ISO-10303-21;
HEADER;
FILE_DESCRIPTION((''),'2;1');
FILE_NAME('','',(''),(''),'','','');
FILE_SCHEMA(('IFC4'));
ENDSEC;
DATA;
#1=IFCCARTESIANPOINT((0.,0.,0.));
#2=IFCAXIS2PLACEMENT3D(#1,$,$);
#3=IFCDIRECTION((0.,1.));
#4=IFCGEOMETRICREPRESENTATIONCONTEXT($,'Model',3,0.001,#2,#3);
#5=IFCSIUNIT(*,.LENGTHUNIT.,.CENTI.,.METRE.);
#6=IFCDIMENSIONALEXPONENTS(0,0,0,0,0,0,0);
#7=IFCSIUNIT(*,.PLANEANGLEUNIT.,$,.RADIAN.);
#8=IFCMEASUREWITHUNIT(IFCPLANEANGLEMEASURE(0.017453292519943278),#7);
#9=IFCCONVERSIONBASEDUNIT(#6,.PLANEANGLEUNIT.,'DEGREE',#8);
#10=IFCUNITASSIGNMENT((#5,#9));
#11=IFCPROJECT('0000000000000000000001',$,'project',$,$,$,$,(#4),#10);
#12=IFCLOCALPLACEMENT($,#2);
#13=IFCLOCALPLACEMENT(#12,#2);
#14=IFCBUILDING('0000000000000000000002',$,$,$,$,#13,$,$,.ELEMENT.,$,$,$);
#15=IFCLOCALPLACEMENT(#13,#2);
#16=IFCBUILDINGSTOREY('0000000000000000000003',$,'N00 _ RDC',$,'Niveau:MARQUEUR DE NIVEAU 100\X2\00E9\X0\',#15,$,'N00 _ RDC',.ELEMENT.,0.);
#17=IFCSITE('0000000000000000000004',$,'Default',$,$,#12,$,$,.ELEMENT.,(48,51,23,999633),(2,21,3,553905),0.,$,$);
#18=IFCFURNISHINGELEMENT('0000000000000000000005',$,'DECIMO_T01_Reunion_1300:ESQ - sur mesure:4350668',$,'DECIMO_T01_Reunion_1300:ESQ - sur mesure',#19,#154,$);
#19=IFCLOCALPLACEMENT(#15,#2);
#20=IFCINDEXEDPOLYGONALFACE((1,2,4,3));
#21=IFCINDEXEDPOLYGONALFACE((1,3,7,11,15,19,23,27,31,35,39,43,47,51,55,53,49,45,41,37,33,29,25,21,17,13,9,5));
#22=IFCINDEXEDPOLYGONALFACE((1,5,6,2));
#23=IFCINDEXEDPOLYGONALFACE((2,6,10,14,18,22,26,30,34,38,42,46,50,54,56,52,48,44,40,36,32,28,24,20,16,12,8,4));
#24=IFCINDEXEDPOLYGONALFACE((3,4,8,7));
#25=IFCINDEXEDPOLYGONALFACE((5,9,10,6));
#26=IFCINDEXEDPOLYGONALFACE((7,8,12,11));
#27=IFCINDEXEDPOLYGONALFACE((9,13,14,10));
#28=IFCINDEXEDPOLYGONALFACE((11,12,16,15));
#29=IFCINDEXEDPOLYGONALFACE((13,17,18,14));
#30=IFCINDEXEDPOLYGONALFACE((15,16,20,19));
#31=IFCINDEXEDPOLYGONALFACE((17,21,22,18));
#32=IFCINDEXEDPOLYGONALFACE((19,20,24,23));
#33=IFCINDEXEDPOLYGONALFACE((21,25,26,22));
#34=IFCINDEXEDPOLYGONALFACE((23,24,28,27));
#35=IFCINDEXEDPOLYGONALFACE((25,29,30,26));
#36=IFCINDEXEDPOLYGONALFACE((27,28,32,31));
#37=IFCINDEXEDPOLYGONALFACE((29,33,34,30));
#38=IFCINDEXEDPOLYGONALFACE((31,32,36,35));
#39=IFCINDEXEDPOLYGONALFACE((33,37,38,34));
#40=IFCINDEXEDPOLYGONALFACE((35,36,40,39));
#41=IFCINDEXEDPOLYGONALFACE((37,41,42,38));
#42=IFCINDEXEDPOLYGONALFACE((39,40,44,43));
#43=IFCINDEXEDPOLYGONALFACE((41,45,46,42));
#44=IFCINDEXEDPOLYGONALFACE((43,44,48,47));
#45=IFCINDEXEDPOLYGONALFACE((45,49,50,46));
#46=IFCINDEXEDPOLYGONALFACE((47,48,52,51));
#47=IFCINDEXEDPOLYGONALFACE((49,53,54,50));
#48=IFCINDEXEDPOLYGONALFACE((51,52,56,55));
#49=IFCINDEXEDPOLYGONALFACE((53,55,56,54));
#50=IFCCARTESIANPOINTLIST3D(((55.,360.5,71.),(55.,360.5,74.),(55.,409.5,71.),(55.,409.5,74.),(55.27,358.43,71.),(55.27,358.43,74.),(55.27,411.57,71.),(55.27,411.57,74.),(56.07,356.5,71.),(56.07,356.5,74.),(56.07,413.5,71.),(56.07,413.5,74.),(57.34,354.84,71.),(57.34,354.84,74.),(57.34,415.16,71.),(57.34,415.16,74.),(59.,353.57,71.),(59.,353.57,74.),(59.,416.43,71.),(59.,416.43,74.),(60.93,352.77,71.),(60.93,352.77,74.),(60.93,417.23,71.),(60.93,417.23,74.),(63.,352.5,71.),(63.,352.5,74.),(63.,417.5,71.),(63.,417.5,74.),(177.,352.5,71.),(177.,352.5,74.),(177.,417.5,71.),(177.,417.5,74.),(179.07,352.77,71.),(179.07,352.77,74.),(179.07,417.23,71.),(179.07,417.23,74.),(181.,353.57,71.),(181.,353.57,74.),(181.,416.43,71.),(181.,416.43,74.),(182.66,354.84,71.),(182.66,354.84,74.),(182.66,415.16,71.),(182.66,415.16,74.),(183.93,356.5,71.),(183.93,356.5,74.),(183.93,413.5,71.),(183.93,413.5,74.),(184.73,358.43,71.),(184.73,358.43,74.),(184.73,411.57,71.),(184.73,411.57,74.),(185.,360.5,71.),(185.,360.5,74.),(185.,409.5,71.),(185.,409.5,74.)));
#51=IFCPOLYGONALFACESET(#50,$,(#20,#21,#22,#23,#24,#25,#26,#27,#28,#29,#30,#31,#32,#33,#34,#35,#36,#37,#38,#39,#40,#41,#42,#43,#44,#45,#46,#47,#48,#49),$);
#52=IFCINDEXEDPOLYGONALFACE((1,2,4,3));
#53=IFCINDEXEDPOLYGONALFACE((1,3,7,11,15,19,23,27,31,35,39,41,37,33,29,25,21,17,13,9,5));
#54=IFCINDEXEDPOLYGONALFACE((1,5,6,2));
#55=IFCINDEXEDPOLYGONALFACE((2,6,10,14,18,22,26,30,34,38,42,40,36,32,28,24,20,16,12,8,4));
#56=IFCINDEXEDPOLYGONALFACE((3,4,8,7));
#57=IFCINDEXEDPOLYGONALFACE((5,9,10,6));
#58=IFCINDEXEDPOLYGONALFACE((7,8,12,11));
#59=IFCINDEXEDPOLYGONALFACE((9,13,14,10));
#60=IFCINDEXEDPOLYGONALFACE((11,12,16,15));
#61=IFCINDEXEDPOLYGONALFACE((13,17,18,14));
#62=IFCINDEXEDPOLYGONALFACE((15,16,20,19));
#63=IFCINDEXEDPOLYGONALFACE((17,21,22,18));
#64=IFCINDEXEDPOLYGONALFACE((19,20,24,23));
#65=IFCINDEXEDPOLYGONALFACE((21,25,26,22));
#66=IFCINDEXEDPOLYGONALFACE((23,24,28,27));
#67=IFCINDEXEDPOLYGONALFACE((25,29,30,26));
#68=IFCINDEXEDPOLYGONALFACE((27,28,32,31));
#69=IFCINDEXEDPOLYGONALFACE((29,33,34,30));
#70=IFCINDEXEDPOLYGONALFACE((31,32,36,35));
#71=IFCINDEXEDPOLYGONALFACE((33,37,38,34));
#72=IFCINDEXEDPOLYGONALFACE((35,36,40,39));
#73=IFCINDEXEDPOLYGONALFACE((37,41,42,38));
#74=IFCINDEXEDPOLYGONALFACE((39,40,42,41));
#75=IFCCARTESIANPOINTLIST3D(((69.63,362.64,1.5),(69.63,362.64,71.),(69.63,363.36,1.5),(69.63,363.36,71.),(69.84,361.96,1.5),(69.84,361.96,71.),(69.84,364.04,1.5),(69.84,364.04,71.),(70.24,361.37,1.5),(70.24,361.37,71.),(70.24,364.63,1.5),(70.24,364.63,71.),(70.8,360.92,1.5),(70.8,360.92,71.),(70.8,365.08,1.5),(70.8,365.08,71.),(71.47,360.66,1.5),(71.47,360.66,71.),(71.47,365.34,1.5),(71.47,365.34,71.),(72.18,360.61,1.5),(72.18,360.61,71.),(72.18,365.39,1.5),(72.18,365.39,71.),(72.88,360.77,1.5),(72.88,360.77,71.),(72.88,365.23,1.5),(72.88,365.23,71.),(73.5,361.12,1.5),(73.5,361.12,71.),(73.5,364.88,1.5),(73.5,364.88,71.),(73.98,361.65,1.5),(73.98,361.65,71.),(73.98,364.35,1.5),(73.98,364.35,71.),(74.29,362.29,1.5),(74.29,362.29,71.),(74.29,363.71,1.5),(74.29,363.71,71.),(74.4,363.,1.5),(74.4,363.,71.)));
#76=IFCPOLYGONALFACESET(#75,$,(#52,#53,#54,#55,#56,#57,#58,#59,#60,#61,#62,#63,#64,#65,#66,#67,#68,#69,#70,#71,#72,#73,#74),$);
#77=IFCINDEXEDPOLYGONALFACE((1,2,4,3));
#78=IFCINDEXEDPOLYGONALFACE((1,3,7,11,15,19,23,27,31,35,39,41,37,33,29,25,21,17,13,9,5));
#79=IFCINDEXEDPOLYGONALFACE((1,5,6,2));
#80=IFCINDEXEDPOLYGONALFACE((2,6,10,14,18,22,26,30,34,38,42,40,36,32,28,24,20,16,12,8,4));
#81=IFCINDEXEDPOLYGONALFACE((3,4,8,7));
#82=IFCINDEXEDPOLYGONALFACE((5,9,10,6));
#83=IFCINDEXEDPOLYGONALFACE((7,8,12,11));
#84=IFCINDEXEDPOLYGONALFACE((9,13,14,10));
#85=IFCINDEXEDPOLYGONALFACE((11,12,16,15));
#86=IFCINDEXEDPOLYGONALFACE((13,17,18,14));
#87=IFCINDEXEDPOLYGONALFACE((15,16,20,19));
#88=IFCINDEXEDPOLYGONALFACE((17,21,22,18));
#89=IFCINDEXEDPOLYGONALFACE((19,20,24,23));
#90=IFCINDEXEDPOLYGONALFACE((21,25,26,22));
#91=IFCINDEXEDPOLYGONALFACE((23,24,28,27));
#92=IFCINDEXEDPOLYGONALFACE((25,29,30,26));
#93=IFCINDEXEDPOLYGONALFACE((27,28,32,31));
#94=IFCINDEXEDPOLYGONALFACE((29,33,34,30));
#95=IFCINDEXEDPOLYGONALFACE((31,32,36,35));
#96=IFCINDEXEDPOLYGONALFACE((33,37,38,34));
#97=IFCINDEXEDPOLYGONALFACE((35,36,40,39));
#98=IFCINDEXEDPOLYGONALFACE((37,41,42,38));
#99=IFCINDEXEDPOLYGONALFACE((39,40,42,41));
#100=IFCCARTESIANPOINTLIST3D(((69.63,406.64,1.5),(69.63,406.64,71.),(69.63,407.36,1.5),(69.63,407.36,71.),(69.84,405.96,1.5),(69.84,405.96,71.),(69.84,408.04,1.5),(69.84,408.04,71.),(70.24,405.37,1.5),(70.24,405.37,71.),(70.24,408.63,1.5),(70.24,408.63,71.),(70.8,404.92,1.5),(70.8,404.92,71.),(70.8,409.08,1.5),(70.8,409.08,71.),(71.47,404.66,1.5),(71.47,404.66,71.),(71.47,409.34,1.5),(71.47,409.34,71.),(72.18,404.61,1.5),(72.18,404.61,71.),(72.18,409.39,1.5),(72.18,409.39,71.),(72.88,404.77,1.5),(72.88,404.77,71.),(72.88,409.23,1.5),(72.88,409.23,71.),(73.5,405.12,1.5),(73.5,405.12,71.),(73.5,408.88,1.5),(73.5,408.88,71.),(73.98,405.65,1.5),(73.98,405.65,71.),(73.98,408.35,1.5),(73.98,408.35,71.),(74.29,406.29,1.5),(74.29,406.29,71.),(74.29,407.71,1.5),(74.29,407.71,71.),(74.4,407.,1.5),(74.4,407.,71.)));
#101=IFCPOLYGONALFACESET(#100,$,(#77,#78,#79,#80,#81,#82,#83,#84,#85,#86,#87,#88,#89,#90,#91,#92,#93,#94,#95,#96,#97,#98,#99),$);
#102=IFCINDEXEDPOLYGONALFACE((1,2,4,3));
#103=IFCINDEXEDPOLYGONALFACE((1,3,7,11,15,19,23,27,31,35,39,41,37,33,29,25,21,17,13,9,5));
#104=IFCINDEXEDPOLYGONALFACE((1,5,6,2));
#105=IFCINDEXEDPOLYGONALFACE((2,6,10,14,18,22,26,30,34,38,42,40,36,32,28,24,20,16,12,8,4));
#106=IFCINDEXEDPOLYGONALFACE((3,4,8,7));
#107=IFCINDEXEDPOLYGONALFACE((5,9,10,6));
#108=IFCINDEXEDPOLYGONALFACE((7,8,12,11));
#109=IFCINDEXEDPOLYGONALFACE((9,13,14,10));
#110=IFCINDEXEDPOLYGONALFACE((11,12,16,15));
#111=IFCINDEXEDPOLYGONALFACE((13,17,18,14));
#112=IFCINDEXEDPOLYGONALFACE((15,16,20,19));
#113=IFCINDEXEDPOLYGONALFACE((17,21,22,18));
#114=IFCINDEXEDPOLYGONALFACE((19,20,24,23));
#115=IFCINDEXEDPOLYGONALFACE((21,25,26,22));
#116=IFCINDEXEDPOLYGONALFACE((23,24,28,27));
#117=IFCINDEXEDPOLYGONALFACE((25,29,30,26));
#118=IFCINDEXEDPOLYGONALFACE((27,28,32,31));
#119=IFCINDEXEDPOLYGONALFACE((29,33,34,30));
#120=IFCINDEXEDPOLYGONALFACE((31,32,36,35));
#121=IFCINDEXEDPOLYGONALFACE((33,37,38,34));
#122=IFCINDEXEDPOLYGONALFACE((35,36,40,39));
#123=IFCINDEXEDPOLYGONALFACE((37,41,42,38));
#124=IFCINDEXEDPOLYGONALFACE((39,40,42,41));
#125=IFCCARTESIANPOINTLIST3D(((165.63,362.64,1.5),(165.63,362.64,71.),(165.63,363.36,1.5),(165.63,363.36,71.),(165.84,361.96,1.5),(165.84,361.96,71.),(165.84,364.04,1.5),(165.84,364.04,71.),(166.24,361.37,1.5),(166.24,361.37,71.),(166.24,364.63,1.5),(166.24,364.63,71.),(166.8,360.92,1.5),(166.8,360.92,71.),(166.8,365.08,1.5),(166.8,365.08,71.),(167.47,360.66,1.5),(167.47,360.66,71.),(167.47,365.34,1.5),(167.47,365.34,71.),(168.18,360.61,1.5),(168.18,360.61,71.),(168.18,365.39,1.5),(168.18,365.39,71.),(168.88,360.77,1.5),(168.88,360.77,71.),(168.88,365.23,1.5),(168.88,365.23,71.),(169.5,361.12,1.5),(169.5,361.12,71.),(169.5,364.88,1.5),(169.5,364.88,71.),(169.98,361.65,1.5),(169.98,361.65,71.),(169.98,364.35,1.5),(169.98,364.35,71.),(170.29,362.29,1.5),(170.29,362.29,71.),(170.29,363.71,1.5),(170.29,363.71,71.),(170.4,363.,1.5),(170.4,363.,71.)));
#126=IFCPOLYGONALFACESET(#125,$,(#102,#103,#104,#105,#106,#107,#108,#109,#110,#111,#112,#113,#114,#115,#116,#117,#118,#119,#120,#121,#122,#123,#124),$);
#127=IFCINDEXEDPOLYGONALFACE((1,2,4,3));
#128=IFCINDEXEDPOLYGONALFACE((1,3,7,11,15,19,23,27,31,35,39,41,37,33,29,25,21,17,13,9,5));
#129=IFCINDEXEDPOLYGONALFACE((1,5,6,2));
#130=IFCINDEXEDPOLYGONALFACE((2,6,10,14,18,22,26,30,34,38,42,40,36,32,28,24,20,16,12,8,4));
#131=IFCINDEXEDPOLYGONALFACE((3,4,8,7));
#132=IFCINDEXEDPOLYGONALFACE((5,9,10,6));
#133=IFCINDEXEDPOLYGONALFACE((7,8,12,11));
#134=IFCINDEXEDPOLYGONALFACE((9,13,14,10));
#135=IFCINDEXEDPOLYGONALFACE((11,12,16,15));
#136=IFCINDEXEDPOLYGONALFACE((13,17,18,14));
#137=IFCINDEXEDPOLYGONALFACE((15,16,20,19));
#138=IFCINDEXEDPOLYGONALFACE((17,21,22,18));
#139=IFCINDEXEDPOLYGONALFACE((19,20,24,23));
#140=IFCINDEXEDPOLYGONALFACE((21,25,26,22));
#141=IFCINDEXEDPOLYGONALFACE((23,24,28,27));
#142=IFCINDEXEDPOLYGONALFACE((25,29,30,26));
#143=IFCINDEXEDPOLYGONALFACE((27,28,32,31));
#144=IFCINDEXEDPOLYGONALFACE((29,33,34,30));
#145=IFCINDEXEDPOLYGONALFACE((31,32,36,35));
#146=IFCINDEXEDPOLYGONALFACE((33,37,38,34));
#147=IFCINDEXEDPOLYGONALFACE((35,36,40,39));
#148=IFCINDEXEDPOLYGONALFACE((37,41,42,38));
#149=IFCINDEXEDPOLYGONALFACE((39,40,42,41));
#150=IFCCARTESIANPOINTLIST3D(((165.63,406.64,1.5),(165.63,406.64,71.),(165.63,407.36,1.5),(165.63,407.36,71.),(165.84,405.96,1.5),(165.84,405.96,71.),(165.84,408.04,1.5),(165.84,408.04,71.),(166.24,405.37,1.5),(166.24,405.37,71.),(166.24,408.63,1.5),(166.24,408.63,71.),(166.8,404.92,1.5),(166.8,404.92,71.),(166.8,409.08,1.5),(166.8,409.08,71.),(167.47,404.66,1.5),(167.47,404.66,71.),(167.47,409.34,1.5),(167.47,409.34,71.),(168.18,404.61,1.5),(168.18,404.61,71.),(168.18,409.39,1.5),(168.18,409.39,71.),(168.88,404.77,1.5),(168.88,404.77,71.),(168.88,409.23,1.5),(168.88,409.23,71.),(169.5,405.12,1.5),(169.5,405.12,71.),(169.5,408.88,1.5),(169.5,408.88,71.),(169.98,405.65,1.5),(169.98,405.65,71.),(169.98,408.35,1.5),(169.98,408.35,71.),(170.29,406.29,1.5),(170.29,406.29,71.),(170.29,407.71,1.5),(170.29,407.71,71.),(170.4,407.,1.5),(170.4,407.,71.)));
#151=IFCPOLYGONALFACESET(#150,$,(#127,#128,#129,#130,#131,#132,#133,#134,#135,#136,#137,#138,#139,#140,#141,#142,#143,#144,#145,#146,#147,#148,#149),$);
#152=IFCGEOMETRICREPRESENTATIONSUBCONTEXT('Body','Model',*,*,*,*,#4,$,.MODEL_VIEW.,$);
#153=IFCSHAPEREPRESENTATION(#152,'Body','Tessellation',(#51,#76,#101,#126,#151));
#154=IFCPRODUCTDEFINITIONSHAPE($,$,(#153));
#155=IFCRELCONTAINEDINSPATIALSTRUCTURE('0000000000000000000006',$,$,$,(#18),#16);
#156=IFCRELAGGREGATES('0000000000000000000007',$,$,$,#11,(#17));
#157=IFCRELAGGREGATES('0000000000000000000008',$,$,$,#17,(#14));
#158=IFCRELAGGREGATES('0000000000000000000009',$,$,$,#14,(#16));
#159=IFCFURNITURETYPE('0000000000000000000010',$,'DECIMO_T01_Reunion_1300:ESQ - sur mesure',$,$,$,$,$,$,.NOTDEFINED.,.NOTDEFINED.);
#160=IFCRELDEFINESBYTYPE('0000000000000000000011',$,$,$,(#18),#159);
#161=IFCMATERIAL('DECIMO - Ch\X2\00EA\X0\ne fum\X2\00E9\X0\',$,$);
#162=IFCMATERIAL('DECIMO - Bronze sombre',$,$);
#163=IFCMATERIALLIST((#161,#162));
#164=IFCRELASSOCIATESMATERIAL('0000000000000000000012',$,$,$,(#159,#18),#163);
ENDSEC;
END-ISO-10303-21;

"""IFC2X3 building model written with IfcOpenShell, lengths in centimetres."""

from ifc_helpers import new_model, entity, si_unit, converted_unit, direction, frame, frame_2d, origin, origin_2d_with_axis, place, context, subcontext, project, spatial, polyline, circle_curve, parameter, trimmed, segment, composite_curve, circle, outline, extrude, source, transform, mapped, material, material_list, type_object, type_shapes, element, save


model = new_model("IFC2X3")

# Units and contexts
model_context = context("Model", 3, precision=0.001, world=origin(), true_north=direction((0.0, 1.0)))
body_context = subcontext(model_context, "Body", "Model", "MODEL_VIEW")
ifc_project = project(units=[si_unit("LENGTHUNIT", "METRE", prefix="CENTI"), converted_unit("PLANEANGLEUNIT", "DEGREE", entity("IfcPlaneAngleMeasure", 0.017453292519943278), si_unit("PLANEANGLEUNIT", "RADIAN"), dimensions=[0, 0, 0, 0, 0, 0, 0])], contexts=[model_context])

# Site, building, storey
site_placement = place(None, origin())
site = spatial("IfcSite", under=ifc_project, at=site_placement, Name="Default", CompositionType="ELEMENT", RefLatitude=(48, 51, 23, 999633), RefLongitude=(2, 21, 3, 553905), RefElevation=0.0)
building_placement = place(site_placement, origin())
building = spatial("IfcBuilding", under=site, at=building_placement, CompositionType="ELEMENT")
storey_placement = place(building_placement, origin())
storey = spatial("IfcBuildingStorey", under=building, at=storey_placement, Name="N00 _ RDC", ObjectType="Niveau:MARQUEUR DE NIVEAU 100é", LongName="N00 _ RDC", CompositionType="ELEMENT", Elevation=0.0)

# Furnishing element
ifc_material_1 = material(Name="DECIMO - Bronze sombre")
ifc_material_2 = material(Name="DECIMO - Chêne fumé")
ifc_material_list_1 = material_list([ifc_material_2, ifc_material_1])
furniture_type_1 = type_object("IfcFurnitureType", Name="DECIMO_T01_Reunion_1300:ESQ - sur mesure", AssemblyPlace="NOTDEFINED", material=ifc_material_list_1)
shared_shape_1 = source(origin(), body_context, "Body", "SweptSolid", [
    extrude(outline(composite_curve([segment(polyline([(-57.0, -32.5), (57.0, -32.5)]), True, "CONTINUOUS"), segment(trimmed(circle_curve(frame_2d((57.0, -24.5), x_axis=(1.0, 0.0)), 8.0), [parameter(270.0)], [parameter(0.0)], True, "PARAMETER"), True, "CONTINUOUS"), segment(polyline([(65.0, -24.5), (65.0, 24.5)]), True, "CONTINUOUS"), segment(trimmed(circle_curve(frame_2d((57.0, 24.5), x_axis=(1.0, 0.0)), 8.0), [parameter(0.0)], [parameter(90.0)], True, "PARAMETER"), True, "CONTINUOUS"), segment(polyline([(57.0, 32.5), (-57.0, 32.5)]), True, "CONTINUOUS"), segment(trimmed(circle_curve(frame_2d((-57.0, 24.5), x_axis=(1.0, 0.0)), 8.0), [parameter(90.0)], [parameter(180.0)], True, "PARAMETER"), True, "CONTINUOUS"), segment(polyline([(-65.0, 24.5), (-65.0, -24.5)]), True, "CONTINUOUS"), segment(trimmed(circle_curve(frame_2d((-57.0, -24.5), x_axis=(1.0, 0.0)), 8.0), [parameter(180.0)], [parameter(270.0)], True, "PARAMETER"), True, "CONTINUOUS")], self_intersect=False)), frame((0.0, 0.0, 71.0)), (0.0, 0.0, 1.0), 3.0),
    extrude(circle(Radius=2.4, at=origin_2d_with_axis()), frame((-48.0, -22.0, 1.5)), (0.0, 0.0, 1.0), 69.5),
    extrude(circle(Radius=2.4, at=origin_2d_with_axis()), frame((-48.0, 22.0, 1.5)), (0.0, 0.0, 1.0), 69.5),
    extrude(circle(Radius=2.4, at=origin_2d_with_axis()), frame((48.0, -22.0, 1.5)), (0.0, 0.0, 1.0), 69.5),
    extrude(circle(Radius=2.4, at=origin_2d_with_axis()), frame((48.0, 22.0, 1.5)), (0.0, 0.0, 1.0), 69.5),
])
type_shapes(furniture_type_1, [shared_shape_1])
furnishing_1_placement = place(storey_placement, frame((120.0, 385.0, 0.0)))
element("IfcFurnishingElement", 1, at=furnishing_1_placement, inside=storey, type_object=furniture_type_1, material=ifc_material_list_1, Name="DECIMO_T01_Reunion_1300:ESQ - sur mesure:4350668", ObjectType="DECIMO_T01_Reunion_1300:ESQ - sur mesure", context=body_context, shape_type="MappedRepresentation", body=[
    mapped(shared_shape_1, transform((0.0, 0.0, 0.0), scale=1.0)),
])

save(model, "model.ifc")
